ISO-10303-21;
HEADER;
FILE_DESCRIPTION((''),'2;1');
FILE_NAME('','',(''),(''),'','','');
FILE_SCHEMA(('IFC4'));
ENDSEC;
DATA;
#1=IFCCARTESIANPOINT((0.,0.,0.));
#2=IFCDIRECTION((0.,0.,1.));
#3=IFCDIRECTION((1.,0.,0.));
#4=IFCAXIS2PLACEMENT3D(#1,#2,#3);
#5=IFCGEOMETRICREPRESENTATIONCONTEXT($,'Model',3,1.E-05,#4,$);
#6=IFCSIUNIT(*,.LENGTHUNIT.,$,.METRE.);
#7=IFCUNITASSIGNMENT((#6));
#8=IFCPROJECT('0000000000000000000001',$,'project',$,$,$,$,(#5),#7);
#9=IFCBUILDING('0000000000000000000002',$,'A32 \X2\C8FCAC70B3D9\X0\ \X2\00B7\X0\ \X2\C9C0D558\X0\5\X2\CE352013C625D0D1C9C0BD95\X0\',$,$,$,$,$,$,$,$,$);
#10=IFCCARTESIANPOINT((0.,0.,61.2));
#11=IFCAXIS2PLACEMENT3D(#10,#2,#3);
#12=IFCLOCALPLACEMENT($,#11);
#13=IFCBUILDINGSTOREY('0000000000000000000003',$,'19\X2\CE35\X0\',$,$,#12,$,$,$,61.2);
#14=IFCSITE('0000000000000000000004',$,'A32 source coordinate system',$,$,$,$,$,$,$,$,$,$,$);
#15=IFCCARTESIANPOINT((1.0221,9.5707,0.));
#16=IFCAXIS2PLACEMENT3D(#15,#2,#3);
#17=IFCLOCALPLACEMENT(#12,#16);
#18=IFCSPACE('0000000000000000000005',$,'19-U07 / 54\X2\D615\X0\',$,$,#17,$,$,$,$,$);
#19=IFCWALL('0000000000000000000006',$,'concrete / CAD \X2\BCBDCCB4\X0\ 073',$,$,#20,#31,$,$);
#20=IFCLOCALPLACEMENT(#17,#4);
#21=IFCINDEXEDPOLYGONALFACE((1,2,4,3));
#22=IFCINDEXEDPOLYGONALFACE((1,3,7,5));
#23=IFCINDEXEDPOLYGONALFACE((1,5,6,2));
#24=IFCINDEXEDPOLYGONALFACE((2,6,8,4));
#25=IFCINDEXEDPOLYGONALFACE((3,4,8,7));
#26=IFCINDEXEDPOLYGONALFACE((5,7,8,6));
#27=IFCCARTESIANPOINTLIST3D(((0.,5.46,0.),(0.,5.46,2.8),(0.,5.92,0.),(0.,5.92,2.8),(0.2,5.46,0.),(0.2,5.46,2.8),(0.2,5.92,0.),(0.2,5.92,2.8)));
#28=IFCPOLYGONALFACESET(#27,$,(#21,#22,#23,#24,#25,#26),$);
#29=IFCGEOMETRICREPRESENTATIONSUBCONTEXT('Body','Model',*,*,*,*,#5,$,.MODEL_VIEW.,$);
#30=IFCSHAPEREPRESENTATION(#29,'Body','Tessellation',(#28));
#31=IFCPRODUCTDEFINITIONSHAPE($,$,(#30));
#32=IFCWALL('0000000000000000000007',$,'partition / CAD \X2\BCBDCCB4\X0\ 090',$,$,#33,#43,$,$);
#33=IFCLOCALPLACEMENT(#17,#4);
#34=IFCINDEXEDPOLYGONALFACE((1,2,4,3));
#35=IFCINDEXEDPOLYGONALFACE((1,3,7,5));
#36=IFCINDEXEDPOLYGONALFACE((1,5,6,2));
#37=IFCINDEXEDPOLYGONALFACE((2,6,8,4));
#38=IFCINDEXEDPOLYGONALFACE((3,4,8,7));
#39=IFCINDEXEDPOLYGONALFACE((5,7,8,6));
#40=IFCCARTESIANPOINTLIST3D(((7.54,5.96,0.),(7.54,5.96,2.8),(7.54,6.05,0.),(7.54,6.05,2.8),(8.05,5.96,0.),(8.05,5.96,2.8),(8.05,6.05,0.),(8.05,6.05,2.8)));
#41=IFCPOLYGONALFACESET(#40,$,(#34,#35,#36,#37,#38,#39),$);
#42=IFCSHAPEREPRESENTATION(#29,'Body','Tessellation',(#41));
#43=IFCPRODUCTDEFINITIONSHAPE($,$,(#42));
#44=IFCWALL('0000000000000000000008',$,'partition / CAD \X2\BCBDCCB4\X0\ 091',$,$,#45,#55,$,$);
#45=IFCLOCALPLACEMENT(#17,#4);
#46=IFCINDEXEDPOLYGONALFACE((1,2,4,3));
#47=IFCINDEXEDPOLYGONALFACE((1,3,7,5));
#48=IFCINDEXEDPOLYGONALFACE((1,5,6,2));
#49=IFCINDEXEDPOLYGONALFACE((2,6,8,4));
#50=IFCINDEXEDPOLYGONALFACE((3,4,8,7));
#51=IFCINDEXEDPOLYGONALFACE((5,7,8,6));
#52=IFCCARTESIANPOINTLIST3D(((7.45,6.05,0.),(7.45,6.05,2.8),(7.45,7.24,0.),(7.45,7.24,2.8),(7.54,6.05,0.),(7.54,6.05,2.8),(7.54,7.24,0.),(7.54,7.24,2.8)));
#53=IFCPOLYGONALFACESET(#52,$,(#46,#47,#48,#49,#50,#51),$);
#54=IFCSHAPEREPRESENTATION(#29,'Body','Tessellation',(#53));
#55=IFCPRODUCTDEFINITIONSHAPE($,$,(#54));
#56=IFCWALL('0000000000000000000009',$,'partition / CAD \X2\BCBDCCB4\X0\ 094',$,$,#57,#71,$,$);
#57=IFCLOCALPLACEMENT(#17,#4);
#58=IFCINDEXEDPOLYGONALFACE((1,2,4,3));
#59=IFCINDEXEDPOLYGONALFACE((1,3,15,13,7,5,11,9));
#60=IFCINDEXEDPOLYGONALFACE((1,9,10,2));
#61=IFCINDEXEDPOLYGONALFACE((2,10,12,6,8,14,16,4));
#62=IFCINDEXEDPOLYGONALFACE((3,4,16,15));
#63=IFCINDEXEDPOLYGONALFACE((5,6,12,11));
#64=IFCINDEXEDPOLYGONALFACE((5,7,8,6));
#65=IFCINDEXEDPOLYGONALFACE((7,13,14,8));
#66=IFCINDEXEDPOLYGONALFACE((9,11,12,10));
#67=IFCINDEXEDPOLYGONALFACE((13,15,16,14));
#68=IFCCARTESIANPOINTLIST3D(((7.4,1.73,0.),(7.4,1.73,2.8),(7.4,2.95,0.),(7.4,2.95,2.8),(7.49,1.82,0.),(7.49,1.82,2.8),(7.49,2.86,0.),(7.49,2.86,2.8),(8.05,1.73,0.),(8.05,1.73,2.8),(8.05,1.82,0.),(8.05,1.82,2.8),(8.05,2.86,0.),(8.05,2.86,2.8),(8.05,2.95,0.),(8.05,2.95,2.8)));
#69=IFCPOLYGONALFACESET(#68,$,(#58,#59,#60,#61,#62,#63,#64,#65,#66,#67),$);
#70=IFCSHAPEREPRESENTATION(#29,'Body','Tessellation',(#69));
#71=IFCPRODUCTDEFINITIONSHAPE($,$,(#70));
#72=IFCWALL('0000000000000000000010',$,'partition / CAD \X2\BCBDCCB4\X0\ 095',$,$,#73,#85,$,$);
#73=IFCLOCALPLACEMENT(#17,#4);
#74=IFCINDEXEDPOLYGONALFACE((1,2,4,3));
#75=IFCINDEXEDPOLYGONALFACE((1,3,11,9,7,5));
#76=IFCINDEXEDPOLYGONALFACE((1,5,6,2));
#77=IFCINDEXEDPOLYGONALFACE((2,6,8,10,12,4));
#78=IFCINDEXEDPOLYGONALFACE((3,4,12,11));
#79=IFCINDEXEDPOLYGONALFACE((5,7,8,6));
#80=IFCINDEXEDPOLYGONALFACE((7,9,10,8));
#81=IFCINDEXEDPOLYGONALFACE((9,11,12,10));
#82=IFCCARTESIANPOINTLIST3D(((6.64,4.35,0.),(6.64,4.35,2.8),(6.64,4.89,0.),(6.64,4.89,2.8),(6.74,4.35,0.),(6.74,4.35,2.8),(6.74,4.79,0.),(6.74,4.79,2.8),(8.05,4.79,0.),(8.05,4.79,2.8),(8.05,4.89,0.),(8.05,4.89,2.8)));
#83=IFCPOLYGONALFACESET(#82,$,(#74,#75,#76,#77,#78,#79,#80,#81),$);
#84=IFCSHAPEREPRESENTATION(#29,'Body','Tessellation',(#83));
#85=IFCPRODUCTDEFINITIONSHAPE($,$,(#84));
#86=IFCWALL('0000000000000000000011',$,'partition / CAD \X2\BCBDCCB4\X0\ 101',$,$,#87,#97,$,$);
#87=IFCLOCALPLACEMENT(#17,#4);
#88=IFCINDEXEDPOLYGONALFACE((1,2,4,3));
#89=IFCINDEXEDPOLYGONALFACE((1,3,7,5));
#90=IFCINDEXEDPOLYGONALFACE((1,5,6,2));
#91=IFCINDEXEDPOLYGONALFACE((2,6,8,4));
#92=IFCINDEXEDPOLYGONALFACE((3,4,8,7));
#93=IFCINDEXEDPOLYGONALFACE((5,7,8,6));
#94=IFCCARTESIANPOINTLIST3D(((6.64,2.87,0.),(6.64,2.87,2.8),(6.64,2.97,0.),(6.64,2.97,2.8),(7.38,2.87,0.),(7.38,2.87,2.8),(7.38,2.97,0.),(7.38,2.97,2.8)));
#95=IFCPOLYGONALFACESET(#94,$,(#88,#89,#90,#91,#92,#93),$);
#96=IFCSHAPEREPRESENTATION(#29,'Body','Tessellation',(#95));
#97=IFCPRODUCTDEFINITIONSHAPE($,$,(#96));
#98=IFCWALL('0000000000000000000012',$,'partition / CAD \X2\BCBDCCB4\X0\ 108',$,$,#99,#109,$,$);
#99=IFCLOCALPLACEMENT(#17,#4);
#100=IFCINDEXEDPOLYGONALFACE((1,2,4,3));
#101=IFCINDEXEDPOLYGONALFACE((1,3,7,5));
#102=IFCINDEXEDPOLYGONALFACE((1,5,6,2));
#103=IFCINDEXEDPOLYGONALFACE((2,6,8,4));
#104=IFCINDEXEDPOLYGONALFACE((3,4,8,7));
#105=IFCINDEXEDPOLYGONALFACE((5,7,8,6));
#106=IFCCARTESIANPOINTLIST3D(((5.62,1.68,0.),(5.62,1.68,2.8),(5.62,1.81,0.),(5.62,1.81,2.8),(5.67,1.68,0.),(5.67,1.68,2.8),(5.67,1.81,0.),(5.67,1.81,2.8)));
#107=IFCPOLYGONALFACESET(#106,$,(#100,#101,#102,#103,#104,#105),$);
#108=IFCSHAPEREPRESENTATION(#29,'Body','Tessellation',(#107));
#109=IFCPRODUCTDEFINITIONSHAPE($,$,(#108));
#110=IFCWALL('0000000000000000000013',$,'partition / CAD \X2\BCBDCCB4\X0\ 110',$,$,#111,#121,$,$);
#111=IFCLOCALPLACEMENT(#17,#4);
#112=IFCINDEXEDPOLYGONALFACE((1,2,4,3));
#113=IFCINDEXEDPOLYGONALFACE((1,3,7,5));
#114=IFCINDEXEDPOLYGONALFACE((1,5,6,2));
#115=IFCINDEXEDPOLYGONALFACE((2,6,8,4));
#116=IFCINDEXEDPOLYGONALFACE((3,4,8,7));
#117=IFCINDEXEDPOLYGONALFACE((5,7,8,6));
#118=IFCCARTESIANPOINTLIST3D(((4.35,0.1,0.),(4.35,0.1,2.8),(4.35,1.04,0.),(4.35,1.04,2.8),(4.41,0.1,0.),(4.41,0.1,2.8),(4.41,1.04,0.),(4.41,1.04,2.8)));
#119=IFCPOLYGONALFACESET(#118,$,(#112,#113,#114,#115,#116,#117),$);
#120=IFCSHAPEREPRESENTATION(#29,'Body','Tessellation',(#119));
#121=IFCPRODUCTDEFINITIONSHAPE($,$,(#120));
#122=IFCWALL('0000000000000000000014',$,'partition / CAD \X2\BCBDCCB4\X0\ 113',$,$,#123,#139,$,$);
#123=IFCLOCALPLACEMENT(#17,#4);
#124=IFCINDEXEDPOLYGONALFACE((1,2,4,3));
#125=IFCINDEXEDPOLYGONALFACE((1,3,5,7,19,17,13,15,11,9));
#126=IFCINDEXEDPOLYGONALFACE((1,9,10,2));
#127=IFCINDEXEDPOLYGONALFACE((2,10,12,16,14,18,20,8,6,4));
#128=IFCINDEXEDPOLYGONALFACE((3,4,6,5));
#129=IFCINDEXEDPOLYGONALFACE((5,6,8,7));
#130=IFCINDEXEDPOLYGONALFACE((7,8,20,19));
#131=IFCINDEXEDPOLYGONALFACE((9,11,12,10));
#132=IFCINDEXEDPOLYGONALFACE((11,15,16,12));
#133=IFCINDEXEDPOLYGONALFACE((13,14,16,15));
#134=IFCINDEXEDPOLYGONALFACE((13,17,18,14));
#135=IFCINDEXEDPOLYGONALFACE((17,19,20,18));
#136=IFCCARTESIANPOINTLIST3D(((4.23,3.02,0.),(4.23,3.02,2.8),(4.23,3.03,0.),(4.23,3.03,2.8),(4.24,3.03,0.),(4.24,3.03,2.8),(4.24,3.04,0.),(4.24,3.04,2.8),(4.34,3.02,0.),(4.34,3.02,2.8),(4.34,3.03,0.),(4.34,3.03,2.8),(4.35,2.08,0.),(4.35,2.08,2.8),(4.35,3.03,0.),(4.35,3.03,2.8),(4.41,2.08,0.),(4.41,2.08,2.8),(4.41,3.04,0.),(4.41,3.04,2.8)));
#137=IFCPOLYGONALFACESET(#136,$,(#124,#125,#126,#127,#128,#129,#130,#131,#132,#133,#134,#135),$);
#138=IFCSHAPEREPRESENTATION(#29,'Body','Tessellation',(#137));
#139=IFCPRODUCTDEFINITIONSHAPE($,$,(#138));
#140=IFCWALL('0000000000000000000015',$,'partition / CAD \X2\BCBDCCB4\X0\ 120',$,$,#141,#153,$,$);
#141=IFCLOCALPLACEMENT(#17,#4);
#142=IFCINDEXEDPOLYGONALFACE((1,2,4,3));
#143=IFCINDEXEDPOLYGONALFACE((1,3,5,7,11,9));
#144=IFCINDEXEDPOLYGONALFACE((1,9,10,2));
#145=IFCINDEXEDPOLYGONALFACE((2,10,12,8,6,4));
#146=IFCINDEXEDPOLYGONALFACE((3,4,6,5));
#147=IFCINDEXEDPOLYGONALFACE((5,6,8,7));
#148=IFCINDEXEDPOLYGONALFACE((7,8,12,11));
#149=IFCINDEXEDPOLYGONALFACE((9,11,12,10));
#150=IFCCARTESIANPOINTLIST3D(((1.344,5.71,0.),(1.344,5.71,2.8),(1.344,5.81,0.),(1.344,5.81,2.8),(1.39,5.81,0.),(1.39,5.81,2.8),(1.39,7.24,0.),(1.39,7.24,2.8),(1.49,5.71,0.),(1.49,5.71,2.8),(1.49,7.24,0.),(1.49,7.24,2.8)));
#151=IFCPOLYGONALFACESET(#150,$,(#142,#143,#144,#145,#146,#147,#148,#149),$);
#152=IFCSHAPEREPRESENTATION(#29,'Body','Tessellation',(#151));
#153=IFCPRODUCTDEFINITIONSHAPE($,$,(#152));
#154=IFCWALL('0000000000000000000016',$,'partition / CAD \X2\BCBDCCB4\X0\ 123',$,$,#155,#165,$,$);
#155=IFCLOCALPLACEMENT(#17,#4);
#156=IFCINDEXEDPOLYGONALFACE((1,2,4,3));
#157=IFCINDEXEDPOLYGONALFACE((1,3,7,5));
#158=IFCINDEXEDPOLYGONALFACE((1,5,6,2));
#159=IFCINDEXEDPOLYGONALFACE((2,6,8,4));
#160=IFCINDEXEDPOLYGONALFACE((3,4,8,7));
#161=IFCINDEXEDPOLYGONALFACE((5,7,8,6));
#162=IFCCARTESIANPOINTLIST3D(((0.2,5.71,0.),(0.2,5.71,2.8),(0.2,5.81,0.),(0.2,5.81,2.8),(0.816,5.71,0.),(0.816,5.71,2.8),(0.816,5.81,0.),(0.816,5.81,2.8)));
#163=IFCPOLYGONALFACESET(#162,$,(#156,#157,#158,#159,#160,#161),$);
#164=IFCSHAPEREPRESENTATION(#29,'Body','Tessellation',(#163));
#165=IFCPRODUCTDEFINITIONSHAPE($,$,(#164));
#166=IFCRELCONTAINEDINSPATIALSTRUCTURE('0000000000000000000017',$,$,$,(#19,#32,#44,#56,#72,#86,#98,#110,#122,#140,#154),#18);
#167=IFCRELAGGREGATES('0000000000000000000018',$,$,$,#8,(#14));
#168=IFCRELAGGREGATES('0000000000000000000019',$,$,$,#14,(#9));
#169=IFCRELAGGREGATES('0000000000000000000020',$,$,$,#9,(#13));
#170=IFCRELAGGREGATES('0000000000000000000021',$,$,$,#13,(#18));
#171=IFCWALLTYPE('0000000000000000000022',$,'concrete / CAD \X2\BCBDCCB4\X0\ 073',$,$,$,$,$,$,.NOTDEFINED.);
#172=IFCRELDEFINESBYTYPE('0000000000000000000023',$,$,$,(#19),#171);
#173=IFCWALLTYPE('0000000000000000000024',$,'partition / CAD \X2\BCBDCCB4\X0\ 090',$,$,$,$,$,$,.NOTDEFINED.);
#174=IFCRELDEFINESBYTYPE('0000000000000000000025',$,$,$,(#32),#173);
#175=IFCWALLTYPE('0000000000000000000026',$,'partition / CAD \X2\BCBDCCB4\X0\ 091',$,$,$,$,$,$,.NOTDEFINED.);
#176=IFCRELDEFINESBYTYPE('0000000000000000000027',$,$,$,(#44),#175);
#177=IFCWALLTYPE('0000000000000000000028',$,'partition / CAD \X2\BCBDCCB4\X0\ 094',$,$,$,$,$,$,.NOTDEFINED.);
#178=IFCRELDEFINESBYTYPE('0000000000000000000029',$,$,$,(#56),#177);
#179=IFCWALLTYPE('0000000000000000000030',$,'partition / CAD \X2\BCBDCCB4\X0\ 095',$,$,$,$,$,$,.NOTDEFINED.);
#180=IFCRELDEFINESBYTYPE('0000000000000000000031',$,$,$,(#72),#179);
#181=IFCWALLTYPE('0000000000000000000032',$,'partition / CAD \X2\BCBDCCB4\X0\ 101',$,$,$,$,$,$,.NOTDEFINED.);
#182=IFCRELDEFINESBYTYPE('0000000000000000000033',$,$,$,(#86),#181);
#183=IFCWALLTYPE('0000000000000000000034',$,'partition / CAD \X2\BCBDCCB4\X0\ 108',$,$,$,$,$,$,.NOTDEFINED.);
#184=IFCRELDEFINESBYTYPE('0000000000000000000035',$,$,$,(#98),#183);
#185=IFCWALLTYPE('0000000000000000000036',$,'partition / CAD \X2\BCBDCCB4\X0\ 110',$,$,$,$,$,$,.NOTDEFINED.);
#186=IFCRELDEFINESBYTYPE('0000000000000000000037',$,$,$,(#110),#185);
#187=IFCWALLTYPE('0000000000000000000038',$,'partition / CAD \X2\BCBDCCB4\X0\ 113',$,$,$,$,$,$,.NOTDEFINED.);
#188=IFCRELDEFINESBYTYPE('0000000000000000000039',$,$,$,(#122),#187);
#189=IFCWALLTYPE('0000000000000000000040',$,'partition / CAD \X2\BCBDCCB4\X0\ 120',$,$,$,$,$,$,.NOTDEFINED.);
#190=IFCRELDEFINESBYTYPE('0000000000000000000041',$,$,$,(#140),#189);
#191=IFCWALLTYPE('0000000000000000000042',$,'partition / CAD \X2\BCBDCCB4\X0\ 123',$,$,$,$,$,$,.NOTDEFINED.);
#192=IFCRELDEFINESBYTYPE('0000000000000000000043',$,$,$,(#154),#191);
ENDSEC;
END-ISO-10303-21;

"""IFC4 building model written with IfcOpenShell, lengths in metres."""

from ifc_helpers import new_model, si_unit, frame, origin, origin_with_axes, place, context, subcontext, project, spatial, polyline, outline, extrude, source, transform, mapped, type_object, type_shapes, element, save


model = new_model("IFC4")

# Units and contexts
model_context = context("Model", 3, precision=1e-05, world=origin_with_axes())
body_context = subcontext(model_context, "Body", "Model", "MODEL_VIEW")
ifc_project = project(units=[si_unit("LENGTHUNIT", "METRE")], contexts=[model_context])

# Site, building, storey, space
site = spatial("IfcSite", under=ifc_project, Name="A32 source coordinate system")
building = spatial("IfcBuilding", under=site, Name="A32 주거동 · 지하5층–옥탑지붕")
storey_placement = place(None, frame((0.0, 0.0, 61.2), z_axis=(0.0, 0.0, 1.0), x_axis=(1.0, 0.0, 0.0)))
storey = spatial("IfcBuildingStorey", under=building, at=storey_placement, Name="19층", Elevation=61.2)
space_1_placement = place(storey_placement, frame((1.0221, 9.5707, 0.0), z_axis=(0.0, 0.0, 1.0), x_axis=(1.0, 0.0, 0.0)))
space_1 = spatial("IfcSpace", under=storey, at=space_1_placement, Name="19-U07 / 54형")

# Walls
wall_type_1 = type_object("IfcWallType", Name="concrete / CAD 벽체 073", PredefinedType="NOTDEFINED")
shared_shape_1 = source(origin(), body_context, "Body", "SweptSolid", [
    extrude(outline(polyline([(0.2, 5.92), (0.2, 5.46), (0.0, 5.46), (0.0, 5.92), (0.2, 5.92)])), origin(), (0.0, 0.0, 1.0), 2.8),
])
type_shapes(wall_type_1, [shared_shape_1])
wall_1_placement = place(space_1_placement, origin_with_axes())
element("IfcWall", 1, at=wall_1_placement, inside=space_1, type_object=wall_type_1, Name="concrete / CAD 벽체 073", context=body_context, shape_type="MappedRepresentation", body=[
    mapped(shared_shape_1, transform((0.0, 0.0, 0.0), scale=1.0)),
])
wall_type_2 = type_object("IfcWallType", Name="partition / CAD 벽체 090", PredefinedType="NOTDEFINED")
shared_shape_2 = source(origin(), body_context, "Body", "SweptSolid", [
    extrude(outline(polyline([(7.54, 5.96), (7.54, 6.05), (8.05, 6.05), (8.05, 5.96), (7.54, 5.96)])), origin(), (0.0, 0.0, 1.0), 2.8),
])
type_shapes(wall_type_2, [shared_shape_2])
wall_2_placement = place(space_1_placement, origin_with_axes())
element("IfcWall", 2, at=wall_2_placement, inside=space_1, type_object=wall_type_2, Name="partition / CAD 벽체 090", context=body_context, shape_type="MappedRepresentation", body=[
    mapped(shared_shape_2, transform((0.0, 0.0, 0.0), scale=1.0)),
])
wall_type_3 = type_object("IfcWallType", Name="partition / CAD 벽체 091", PredefinedType="NOTDEFINED")
shared_shape_3 = source(origin(), body_context, "Body", "SweptSolid", [
    extrude(outline(polyline([(7.54, 6.05), (7.45, 6.05), (7.45, 7.24), (7.54, 7.24), (7.54, 6.05)])), origin(), (0.0, 0.0, 1.0), 2.8),
])
type_shapes(wall_type_3, [shared_shape_3])
wall_3_placement = place(space_1_placement, origin_with_axes())
element("IfcWall", 3, at=wall_3_placement, inside=space_1, type_object=wall_type_3, Name="partition / CAD 벽체 091", context=body_context, shape_type="MappedRepresentation", body=[
    mapped(shared_shape_3, transform((0.0, 0.0, 0.0), scale=1.0)),
])
wall_type_4 = type_object("IfcWallType", Name="partition / CAD 벽체 094", PredefinedType="NOTDEFINED")
shared_shape_4 = source(origin(), body_context, "Body", "SweptSolid", [
    extrude(outline(polyline([(8.05, 1.73), (7.4, 1.73), (7.4, 2.95), (8.05, 2.95), (8.05, 2.86), (7.49, 2.86), (7.49, 1.82), (8.05, 1.82), (8.05, 1.73)])), origin(), (0.0, 0.0, 1.0), 2.8),
])
type_shapes(wall_type_4, [shared_shape_4])
wall_4_placement = place(space_1_placement, origin_with_axes())
element("IfcWall", 4, at=wall_4_placement, inside=space_1, type_object=wall_type_4, Name="partition / CAD 벽체 094", context=body_context, shape_type="MappedRepresentation", body=[
    mapped(shared_shape_4, transform((0.0, 0.0, 0.0), scale=1.0)),
])
wall_type_5 = type_object("IfcWallType", Name="partition / CAD 벽체 095", PredefinedType="NOTDEFINED")
shared_shape_5 = source(origin(), body_context, "Body", "SweptSolid", [
    extrude(outline(polyline([(6.64, 4.89), (8.05, 4.89), (8.05, 4.79), (6.74, 4.79), (6.74, 4.35), (6.64, 4.35), (6.64, 4.89)])), origin(), (0.0, 0.0, 1.0), 2.8),
])
type_shapes(wall_type_5, [shared_shape_5])
wall_5_placement = place(space_1_placement, origin_with_axes())
element("IfcWall", 5, at=wall_5_placement, inside=space_1, type_object=wall_type_5, Name="partition / CAD 벽체 095", context=body_context, shape_type="MappedRepresentation", body=[
    mapped(shared_shape_5, transform((0.0, 0.0, 0.0), scale=1.0)),
])
wall_type_6 = type_object("IfcWallType", Name="partition / CAD 벽체 101", PredefinedType="NOTDEFINED")
shared_shape_6 = source(origin(), body_context, "Body", "SweptSolid", [
    extrude(outline(polyline([(7.38, 2.97), (7.38, 2.87), (6.64, 2.87), (6.64, 2.97), (7.38, 2.97)])), origin(), (0.0, 0.0, 1.0), 2.8),
])
type_shapes(wall_type_6, [shared_shape_6])
wall_6_placement = place(space_1_placement, origin_with_axes())
element("IfcWall", 6, at=wall_6_placement, inside=space_1, type_object=wall_type_6, Name="partition / CAD 벽체 101", context=body_context, shape_type="MappedRepresentation", body=[
    mapped(shared_shape_6, transform((0.0, 0.0, 0.0), scale=1.0)),
])
wall_type_7 = type_object("IfcWallType", Name="partition / CAD 벽체 108", PredefinedType="NOTDEFINED")
shared_shape_7 = source(origin(), body_context, "Body", "SweptSolid", [
    extrude(outline(polyline([(5.67, 1.68), (5.62, 1.68), (5.62, 1.81), (5.67, 1.81), (5.67, 1.68)])), origin(), (0.0, 0.0, 1.0), 2.8),
])
type_shapes(wall_type_7, [shared_shape_7])
wall_7_placement = place(space_1_placement, origin_with_axes())
element("IfcWall", 7, at=wall_7_placement, inside=space_1, type_object=wall_type_7, Name="partition / CAD 벽체 108", context=body_context, shape_type="MappedRepresentation", body=[
    mapped(shared_shape_7, transform((0.0, 0.0, 0.0), scale=1.0)),
])
wall_type_8 = type_object("IfcWallType", Name="partition / CAD 벽체 110", PredefinedType="NOTDEFINED")
shared_shape_8 = source(origin(), body_context, "Body", "SweptSolid", [
    extrude(outline(polyline([(4.35, 1.04), (4.41, 1.04), (4.41, 0.1), (4.35, 0.1), (4.35, 1.04)])), origin(), (0.0, 0.0, 1.0), 2.8),
])
type_shapes(wall_type_8, [shared_shape_8])
wall_8_placement = place(space_1_placement, origin_with_axes())
element("IfcWall", 8, at=wall_8_placement, inside=space_1, type_object=wall_type_8, Name="partition / CAD 벽체 110", context=body_context, shape_type="MappedRepresentation", body=[
    mapped(shared_shape_8, transform((0.0, 0.0, 0.0), scale=1.0)),
])
wall_type_9 = type_object("IfcWallType", Name="partition / CAD 벽체 113", PredefinedType="NOTDEFINED")
shared_shape_9 = source(origin(), body_context, "Body", "SweptSolid", [
    extrude(outline(polyline([(4.24, 3.04), (4.41, 3.04), (4.41, 2.08), (4.35, 2.08), (4.35, 3.03), (4.34, 3.03), (4.34, 3.02), (4.23, 3.02), (4.23, 3.03), (4.24, 3.03), (4.24, 3.04)])), origin(), (0.0, 0.0, 1.0), 2.8),
])
type_shapes(wall_type_9, [shared_shape_9])
wall_9_placement = place(space_1_placement, origin_with_axes())
element("IfcWall", 9, at=wall_9_placement, inside=space_1, type_object=wall_type_9, Name="partition / CAD 벽체 113", context=body_context, shape_type="MappedRepresentation", body=[
    mapped(shared_shape_9, transform((0.0, 0.0, 0.0), scale=1.0)),
])
wall_type_10 = type_object("IfcWallType", Name="partition / CAD 벽체 120", PredefinedType="NOTDEFINED")
shared_shape_10 = source(origin(), body_context, "Body", "SweptSolid", [
    extrude(outline(polyline([(1.39, 7.24), (1.49, 7.24), (1.49, 5.71), (1.344, 5.71), (1.344, 5.81), (1.39, 5.81), (1.39, 7.24)])), origin(), (0.0, 0.0, 1.0), 2.8),
])
type_shapes(wall_type_10, [shared_shape_10])
wall_10_placement = place(space_1_placement, origin_with_axes())
element("IfcWall", 10, at=wall_10_placement, inside=space_1, type_object=wall_type_10, Name="partition / CAD 벽체 120", context=body_context, shape_type="MappedRepresentation", body=[
    mapped(shared_shape_10, transform((0.0, 0.0, 0.0), scale=1.0)),
])
wall_type_11 = type_object("IfcWallType", Name="partition / CAD 벽체 123", PredefinedType="NOTDEFINED")
shared_shape_11 = source(origin(), body_context, "Body", "SweptSolid", [
    extrude(outline(polyline([(0.816, 5.81), (0.816, 5.71), (0.2, 5.71), (0.2, 5.81), (0.816, 5.81)])), origin(), (0.0, 0.0, 1.0), 2.8),
])
type_shapes(wall_type_11, [shared_shape_11])
wall_11_placement = place(space_1_placement, origin_with_axes())
element("IfcWall", 11, at=wall_11_placement, inside=space_1, type_object=wall_type_11, Name="partition / CAD 벽체 123", context=body_context, shape_type="MappedRepresentation", body=[
    mapped(shared_shape_11, transform((0.0, 0.0, 0.0), scale=1.0)),
])

save(model, "model.ifc")
